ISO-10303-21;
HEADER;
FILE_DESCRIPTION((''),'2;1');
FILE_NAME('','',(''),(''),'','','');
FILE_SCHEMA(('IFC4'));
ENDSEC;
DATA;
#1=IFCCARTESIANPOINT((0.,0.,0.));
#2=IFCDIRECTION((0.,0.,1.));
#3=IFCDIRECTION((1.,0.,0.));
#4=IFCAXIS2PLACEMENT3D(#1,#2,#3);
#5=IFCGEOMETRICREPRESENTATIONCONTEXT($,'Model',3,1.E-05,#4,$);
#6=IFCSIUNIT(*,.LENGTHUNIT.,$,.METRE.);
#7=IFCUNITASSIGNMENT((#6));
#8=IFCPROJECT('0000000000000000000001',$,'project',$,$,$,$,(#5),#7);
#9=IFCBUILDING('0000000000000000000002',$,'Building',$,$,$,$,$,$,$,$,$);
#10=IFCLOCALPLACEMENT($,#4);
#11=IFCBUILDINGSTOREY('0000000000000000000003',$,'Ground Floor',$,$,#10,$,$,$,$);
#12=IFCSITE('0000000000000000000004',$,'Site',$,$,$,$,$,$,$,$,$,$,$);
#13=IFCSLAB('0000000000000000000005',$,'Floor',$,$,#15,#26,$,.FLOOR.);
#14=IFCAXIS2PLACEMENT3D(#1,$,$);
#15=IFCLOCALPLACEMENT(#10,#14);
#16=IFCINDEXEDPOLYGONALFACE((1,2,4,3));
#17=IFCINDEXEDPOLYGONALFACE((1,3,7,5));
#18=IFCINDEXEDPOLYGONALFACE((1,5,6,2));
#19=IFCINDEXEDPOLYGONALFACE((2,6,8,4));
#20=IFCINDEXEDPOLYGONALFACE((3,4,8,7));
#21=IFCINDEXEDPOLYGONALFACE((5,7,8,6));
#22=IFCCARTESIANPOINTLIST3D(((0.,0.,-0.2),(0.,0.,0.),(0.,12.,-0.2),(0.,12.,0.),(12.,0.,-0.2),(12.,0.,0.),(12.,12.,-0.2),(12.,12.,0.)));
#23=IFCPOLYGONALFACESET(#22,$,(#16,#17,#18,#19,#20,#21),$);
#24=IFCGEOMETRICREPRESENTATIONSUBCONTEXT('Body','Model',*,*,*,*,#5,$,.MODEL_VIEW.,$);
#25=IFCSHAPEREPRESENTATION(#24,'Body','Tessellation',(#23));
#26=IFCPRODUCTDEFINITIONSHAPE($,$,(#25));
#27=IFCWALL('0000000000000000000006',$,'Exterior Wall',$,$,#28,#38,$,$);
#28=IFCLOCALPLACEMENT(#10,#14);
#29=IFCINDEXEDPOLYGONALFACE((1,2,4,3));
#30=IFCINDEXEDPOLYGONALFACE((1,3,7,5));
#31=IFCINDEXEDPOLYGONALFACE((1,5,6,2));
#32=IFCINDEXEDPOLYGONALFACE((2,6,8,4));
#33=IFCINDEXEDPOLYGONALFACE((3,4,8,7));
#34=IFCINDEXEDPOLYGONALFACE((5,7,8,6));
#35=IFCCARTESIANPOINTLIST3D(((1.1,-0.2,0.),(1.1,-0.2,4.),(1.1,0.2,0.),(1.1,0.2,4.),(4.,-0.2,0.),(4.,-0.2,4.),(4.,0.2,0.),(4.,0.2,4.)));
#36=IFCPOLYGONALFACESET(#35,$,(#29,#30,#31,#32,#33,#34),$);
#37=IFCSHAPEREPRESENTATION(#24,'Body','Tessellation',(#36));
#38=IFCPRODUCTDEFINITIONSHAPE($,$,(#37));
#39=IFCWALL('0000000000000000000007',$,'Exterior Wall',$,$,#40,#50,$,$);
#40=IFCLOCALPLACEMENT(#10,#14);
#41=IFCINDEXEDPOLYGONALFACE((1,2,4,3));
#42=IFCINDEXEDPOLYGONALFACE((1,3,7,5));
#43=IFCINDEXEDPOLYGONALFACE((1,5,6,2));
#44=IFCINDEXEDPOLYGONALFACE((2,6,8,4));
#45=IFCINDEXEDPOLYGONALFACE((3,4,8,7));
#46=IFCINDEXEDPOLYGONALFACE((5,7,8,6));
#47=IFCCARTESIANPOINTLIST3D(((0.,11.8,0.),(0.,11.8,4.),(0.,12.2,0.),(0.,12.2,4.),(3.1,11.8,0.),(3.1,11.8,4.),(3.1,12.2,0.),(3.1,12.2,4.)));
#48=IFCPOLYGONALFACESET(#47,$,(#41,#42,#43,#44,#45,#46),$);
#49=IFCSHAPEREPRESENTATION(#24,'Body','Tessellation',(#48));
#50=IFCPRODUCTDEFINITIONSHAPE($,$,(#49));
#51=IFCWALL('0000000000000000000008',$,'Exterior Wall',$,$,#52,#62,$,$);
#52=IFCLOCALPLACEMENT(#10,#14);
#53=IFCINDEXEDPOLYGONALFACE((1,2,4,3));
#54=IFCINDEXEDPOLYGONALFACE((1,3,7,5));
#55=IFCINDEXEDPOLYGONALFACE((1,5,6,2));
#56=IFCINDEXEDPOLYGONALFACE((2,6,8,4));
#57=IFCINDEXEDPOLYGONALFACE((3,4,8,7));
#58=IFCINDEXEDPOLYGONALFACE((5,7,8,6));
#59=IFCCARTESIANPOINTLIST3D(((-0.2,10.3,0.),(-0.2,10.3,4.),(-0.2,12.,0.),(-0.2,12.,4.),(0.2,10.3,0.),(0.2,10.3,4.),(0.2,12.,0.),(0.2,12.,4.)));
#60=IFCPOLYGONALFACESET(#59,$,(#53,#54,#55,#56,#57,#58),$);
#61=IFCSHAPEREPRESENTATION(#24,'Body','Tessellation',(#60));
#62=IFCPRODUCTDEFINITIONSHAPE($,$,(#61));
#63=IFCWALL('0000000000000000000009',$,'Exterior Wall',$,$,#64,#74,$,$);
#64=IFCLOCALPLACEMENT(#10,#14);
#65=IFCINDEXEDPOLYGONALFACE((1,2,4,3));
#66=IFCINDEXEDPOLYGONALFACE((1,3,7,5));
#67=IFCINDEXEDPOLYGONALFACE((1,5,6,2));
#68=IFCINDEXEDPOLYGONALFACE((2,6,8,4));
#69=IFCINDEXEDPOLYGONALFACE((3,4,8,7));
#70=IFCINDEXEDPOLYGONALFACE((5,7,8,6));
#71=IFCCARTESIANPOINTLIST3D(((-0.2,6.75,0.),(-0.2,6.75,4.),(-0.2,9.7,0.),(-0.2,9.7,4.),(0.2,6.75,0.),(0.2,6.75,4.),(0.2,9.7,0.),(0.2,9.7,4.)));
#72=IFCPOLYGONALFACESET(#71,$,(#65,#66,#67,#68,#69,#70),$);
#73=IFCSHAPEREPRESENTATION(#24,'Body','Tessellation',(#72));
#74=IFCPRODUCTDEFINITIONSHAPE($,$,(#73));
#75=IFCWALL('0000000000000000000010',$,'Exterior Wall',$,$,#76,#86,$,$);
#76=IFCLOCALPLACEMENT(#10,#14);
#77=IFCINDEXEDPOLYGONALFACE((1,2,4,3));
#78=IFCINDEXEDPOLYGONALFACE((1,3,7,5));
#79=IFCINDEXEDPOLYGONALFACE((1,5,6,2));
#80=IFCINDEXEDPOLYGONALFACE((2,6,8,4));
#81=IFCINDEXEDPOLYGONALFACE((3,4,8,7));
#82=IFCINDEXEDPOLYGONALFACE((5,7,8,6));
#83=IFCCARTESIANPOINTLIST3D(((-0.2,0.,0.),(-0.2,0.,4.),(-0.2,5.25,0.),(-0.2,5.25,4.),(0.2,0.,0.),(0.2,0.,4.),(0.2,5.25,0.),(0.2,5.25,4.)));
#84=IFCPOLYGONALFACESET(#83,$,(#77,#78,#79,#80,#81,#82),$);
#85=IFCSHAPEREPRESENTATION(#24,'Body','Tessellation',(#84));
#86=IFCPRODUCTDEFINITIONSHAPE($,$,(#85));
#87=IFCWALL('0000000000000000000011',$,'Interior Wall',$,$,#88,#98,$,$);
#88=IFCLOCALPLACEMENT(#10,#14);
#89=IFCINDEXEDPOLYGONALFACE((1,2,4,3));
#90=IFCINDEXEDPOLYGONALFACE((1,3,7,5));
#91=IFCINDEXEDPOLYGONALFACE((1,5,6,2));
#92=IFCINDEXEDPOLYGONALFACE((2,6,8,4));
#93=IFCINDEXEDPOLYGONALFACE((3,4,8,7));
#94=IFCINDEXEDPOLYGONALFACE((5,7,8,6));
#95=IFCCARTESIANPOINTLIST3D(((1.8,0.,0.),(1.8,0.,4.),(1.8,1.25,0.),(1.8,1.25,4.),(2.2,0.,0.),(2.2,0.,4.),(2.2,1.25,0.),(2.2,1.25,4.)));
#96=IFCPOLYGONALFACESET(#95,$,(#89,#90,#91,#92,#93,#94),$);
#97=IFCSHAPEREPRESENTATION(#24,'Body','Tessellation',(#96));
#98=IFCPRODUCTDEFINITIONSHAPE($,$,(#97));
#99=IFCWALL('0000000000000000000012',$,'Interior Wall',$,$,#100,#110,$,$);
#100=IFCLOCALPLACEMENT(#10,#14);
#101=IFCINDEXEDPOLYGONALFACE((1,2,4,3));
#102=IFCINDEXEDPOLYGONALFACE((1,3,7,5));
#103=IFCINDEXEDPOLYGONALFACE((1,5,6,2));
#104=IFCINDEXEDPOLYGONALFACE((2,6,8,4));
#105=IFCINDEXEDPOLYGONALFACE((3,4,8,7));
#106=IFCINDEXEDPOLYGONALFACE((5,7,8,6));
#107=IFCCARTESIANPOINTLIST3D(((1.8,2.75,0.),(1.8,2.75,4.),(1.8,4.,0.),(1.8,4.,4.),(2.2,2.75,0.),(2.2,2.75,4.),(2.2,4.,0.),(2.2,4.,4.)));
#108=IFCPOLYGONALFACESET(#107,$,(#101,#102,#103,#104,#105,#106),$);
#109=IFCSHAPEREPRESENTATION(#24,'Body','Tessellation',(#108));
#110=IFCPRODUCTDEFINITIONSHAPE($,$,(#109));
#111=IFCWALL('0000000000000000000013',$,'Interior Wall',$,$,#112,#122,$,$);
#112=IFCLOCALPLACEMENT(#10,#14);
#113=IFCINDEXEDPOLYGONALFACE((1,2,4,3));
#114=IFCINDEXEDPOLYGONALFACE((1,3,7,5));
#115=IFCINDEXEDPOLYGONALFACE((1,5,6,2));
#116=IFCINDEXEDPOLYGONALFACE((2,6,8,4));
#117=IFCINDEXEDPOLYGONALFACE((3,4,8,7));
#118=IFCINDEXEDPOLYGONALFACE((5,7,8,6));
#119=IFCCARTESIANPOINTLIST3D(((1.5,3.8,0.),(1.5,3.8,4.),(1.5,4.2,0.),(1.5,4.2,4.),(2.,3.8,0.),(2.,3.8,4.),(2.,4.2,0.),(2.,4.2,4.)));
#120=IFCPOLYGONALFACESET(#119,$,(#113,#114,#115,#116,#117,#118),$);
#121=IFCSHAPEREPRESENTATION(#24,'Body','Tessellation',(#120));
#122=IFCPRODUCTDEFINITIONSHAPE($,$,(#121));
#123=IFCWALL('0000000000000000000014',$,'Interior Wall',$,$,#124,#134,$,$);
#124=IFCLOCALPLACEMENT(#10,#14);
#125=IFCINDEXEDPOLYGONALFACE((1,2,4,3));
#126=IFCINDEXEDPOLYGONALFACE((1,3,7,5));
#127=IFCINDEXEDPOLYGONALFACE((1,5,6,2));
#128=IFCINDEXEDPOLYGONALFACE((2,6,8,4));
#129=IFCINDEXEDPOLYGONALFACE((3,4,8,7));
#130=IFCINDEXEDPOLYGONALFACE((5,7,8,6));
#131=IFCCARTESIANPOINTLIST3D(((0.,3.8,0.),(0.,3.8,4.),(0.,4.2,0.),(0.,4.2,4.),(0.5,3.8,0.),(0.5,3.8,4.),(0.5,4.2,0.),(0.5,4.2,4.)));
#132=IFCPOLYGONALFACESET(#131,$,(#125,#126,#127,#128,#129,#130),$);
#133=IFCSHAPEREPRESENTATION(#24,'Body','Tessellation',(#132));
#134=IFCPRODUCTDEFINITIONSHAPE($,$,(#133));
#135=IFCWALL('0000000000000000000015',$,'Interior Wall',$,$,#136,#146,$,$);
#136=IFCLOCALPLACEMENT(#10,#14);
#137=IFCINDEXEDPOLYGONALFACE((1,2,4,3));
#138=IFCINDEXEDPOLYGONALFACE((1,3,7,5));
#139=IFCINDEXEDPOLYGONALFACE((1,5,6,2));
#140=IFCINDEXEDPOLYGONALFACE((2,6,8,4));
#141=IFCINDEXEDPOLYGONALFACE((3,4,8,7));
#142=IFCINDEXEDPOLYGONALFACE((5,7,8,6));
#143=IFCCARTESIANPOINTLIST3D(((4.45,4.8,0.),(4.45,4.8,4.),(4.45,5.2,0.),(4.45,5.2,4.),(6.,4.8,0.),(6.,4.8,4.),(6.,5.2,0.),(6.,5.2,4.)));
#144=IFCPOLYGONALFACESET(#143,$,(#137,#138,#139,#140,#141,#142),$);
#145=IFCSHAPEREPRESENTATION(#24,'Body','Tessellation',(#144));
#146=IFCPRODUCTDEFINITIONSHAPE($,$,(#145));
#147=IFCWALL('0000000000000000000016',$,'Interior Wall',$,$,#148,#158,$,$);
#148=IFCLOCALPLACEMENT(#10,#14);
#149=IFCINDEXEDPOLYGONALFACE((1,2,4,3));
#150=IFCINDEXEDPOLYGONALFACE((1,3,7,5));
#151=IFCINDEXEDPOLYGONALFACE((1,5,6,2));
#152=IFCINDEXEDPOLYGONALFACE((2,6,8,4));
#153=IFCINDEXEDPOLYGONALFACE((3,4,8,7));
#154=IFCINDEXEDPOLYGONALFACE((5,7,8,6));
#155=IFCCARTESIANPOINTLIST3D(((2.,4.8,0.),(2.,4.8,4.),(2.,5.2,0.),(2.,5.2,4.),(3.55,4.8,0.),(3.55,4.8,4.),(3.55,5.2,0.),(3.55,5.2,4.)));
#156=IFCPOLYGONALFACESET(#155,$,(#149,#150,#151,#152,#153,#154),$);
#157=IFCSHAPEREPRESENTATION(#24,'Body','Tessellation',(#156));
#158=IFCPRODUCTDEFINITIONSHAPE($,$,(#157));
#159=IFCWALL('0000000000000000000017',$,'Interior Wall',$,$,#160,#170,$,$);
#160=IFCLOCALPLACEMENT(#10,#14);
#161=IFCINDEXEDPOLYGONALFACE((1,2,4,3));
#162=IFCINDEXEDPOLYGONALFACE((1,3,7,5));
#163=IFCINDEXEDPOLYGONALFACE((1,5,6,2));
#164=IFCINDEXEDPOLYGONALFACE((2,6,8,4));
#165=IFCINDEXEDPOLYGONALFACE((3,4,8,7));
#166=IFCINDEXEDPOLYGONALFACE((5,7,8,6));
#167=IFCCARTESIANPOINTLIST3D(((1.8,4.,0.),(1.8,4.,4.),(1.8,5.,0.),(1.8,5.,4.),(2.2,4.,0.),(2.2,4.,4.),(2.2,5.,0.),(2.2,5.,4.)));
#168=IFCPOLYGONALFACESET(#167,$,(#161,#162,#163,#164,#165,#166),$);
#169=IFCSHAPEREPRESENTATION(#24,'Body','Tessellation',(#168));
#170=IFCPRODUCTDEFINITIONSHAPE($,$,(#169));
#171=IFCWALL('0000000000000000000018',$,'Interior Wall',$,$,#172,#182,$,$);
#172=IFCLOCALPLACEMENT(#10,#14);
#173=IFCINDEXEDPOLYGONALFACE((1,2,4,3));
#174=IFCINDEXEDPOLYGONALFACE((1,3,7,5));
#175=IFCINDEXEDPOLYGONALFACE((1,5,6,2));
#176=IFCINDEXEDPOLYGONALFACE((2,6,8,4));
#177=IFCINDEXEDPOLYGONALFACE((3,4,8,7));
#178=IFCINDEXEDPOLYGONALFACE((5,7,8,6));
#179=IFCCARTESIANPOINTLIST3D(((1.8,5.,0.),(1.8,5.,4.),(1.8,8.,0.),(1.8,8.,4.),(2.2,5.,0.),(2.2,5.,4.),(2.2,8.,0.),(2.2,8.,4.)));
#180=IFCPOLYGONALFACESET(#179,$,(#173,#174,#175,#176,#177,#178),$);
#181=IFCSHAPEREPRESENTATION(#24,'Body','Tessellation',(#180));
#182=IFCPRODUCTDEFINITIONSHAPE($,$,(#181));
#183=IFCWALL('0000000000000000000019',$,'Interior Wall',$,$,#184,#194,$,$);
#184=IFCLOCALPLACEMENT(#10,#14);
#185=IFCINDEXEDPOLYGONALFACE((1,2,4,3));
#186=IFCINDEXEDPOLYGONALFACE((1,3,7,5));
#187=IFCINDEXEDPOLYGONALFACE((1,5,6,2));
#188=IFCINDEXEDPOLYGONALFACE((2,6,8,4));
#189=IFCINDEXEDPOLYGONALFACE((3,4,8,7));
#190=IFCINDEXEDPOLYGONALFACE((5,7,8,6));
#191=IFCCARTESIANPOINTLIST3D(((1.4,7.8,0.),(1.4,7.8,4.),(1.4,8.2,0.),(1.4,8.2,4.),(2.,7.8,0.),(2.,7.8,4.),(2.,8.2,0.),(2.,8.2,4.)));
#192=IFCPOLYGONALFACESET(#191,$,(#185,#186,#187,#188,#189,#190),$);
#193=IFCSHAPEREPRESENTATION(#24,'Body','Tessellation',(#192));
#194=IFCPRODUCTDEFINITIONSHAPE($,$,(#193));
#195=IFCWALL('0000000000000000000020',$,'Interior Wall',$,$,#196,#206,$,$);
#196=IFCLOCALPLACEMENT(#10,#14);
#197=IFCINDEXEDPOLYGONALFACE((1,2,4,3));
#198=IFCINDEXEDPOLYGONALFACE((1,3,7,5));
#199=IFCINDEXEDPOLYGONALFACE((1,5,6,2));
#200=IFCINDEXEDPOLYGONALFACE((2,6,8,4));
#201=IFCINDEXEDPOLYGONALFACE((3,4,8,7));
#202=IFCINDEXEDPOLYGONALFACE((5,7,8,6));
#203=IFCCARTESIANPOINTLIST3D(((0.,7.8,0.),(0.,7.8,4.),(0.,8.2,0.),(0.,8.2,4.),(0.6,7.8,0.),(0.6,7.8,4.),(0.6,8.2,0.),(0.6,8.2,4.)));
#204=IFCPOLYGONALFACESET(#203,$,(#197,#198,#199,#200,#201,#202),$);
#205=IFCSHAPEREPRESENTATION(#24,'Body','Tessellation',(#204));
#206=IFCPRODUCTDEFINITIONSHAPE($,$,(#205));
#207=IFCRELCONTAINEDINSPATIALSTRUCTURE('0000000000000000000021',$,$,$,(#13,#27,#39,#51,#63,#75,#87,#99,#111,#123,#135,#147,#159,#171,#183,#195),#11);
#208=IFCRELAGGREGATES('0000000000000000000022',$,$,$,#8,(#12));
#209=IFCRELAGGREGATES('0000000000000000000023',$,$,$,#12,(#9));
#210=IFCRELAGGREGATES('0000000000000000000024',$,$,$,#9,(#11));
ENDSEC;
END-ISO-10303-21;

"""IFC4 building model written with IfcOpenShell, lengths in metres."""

from ifc_helpers import new_model, si_unit, frame, origin_with_axes, place, context, subcontext, project, spatial, indexed_curve, outline, extrude, element, save


model = new_model("IFC4")

# Units and contexts
model_context = context("Model", 3, precision=1e-05, world=origin_with_axes())
body_context = subcontext(model_context, "Body", "Model", "MODEL_VIEW")
ifc_project = project(units=[si_unit("LENGTHUNIT", "METRE")], contexts=[model_context])

# Site, building, storey
site = spatial("IfcSite", under=ifc_project, Name="Site")
building = spatial("IfcBuilding", under=site, Name="Building")
storey_placement = place(None, origin_with_axes())
storey = spatial("IfcBuildingStorey", under=building, at=storey_placement, Name="Ground Floor")

# Slab
slab_placement = place(storey_placement, frame((0.0, 0.0, -0.2), z_axis=(0.0, 0.0, 1.0), x_axis=(1.0, 0.0, 0.0)))
element("IfcSlab", 1, at=slab_placement, inside=storey, Name="Floor", PredefinedType="FLOOR", context=body_context, shape_type="SweptSolid", body=[
    extrude(outline(indexed_curve([(0.0, 0.0), (12.0, 0.0), (12.0, 12.0), (0.0, 12.0)])), None, (0.0, 0.0, 1.0), 0.2),
])

# Walls
wall_1_placement = place(storey_placement, frame((1.1, 0.0, 0.0), z_axis=(0.0, 0.0, 1.0), x_axis=(1.0, 0.0, 0.0)))
element("IfcWall", 2, at=wall_1_placement, inside=storey, Name="Exterior Wall", context=body_context, shape_type="SweptSolid", body=[
    extrude(outline(indexed_curve([(0.0, 0.0), (0.0, 0.4), (2.9, 0.4), (2.9, 0.0), (0.0, 0.0)], self_intersect=False)), frame((0.0, -0.2, 0.0), z_axis=(0.0, 0.0, 1.0), x_axis=(1.0, 0.0, 0.0)), (0.0, 0.0, 1.0), 4.0),
])
wall_2_placement = place(storey_placement, frame((3.1, 12.0, 0.0), z_axis=(0.0, 0.0, 1.0), x_axis=(-1.0, 0.0, 0.0)))
element("IfcWall", 3, at=wall_2_placement, inside=storey, Name="Exterior Wall", context=body_context, shape_type="SweptSolid", body=[
    extrude(outline(indexed_curve([(0.0, 0.0), (0.0, 0.4), (3.1, 0.4), (3.1, 0.0), (0.0, 0.0)], self_intersect=False)), frame((0.0, -0.2, 0.0), z_axis=(0.0, 0.0, 1.0), x_axis=(1.0, 0.0, 0.0)), (0.0, 0.0, 1.0), 4.0),
])
wall_3_placement = place(storey_placement, frame((0.0, 12.0, 0.0), z_axis=(0.0, 0.0, 1.0), x_axis=(0.0, -1.0, 0.0)))
element("IfcWall", 4, at=wall_3_placement, inside=storey, Name="Exterior Wall", context=body_context, shape_type="SweptSolid", body=[
    extrude(outline(indexed_curve([(0.0, 0.0), (0.0, 0.4), (1.7, 0.4), (1.7, 0.0), (0.0, 0.0)], self_intersect=False)), frame((0.0, -0.2, 0.0), z_axis=(0.0, 0.0, 1.0), x_axis=(1.0, 0.0, 0.0)), (0.0, 0.0, 1.0), 4.0),
])
wall_4_placement = place(storey_placement, frame((0.0, 9.7, 0.0), z_axis=(0.0, 0.0, 1.0), x_axis=(0.0, -1.0, 0.0)))
element("IfcWall", 5, at=wall_4_placement, inside=storey, Name="Exterior Wall", context=body_context, shape_type="SweptSolid", body=[
    extrude(outline(indexed_curve([(0.0, 0.0), (0.0, 0.4), (2.95, 0.4), (2.95, 0.0), (0.0, 0.0)], self_intersect=False)), frame((0.0, -0.2, 0.0), z_axis=(0.0, 0.0, 1.0), x_axis=(1.0, 0.0, 0.0)), (0.0, 0.0, 1.0), 4.0),
])
wall_5_placement = place(storey_placement, frame((0.0, 5.25, 0.0), z_axis=(0.0, 0.0, 1.0), x_axis=(0.0, -1.0, 0.0)))
element("IfcWall", 6, at=wall_5_placement, inside=storey, Name="Exterior Wall", context=body_context, shape_type="SweptSolid", body=[
    extrude(outline(indexed_curve([(0.0, 0.0), (0.0, 0.4), (5.25, 0.4), (5.25, 0.0), (0.0, 0.0)], self_intersect=False)), frame((0.0, -0.2, 0.0), z_axis=(0.0, 0.0, 1.0), x_axis=(1.0, 0.0, 0.0)), (0.0, 0.0, 1.0), 4.0),
])
for number, where, z_axis, x_axis, name in (
    (7, (2.0, 0.0, 0.0), (0.0, 0.0, 1.0), (0.0, 1.0, 0.0), "Interior Wall"),
    (8, (2.0, 2.75, 0.0), (0.0, 0.0, 1.0), (0.0, 1.0, 0.0), "Interior Wall"),
):
    element("IfcWall", number, at=place(storey_placement, frame(where, z_axis=z_axis, x_axis=x_axis)), inside=storey, Name=name, context=body_context, shape_type="SweptSolid", body=[
        extrude(outline(indexed_curve([(0.0, 0.0), (0.0, 0.4), (1.25, 0.4), (1.25, 0.0), (0.0, 0.0)], self_intersect=False)), frame((0.0, -0.2, 0.0), z_axis=(0.0, 0.0, 1.0), x_axis=(1.0, 0.0, 0.0)), (0.0, 0.0, 1.0), 4.0),
    ])
for number, where, z_axis, x_axis, name in (
    (9, (2.0, 4.0, 0.0), (0.0, 0.0, 1.0), (-1.0, 0.0, 0.0), "Interior Wall"),
    (10, (0.5, 4.0, 0.0), (0.0, 0.0, 1.0), (-1.0, 0.0, 0.0), "Interior Wall"),
):
    element("IfcWall", number, at=place(storey_placement, frame(where, z_axis=z_axis, x_axis=x_axis)), inside=storey, Name=name, context=body_context, shape_type="SweptSolid", body=[
        extrude(outline(indexed_curve([(0.0, 0.0), (0.0, 0.4), (0.5, 0.4), (0.5, 0.0), (0.0, 0.0)], self_intersect=False)), frame((0.0, -0.2, 0.0), z_axis=(0.0, 0.0, 1.0), x_axis=(1.0, 0.0, 0.0)), (0.0, 0.0, 1.0), 4.0),
    ])
for number, where, z_axis, x_axis, name in (
    (11, (6.0, 5.0, 0.0), (0.0, 0.0, 1.0), (-1.0, 0.0, 0.0), "Interior Wall"),
    (12, (3.55, 5.0, 0.0), (0.0, 0.0, 1.0), (-1.0, 0.0, 0.0), "Interior Wall"),
):
    element("IfcWall", number, at=place(storey_placement, frame(where, z_axis=z_axis, x_axis=x_axis)), inside=storey, Name=name, context=body_context, shape_type="SweptSolid", body=[
        extrude(outline(indexed_curve([(0.0, 0.0), (0.0, 0.4), (1.55, 0.4), (1.55, 0.0), (0.0, 0.0)], self_intersect=False)), frame((0.0, -0.2, 0.0), z_axis=(0.0, 0.0, 1.0), x_axis=(1.0, 0.0, 0.0)), (0.0, 0.0, 1.0), 4.0),
    ])
wall_6_placement = place(storey_placement, frame((2.0, 5.0, 0.0), z_axis=(0.0, 0.0, 1.0), x_axis=(0.0, -1.0, 0.0)))
element("IfcWall", 13, at=wall_6_placement, inside=storey, Name="Interior Wall", context=body_context, shape_type="SweptSolid", body=[
    extrude(outline(indexed_curve([(0.0, 0.0), (0.0, 0.4), (1.0, 0.4), (1.0, 0.0), (0.0, 0.0)], self_intersect=False)), frame((0.0, -0.2, 0.0), z_axis=(0.0, 0.0, 1.0), x_axis=(1.0, 0.0, 0.0)), (0.0, 0.0, 1.0), 4.0),
])
wall_7_placement = place(storey_placement, frame((2.0, 5.0, 0.0), z_axis=(0.0, 0.0, 1.0), x_axis=(0.0, 1.0, 0.0)))
element("IfcWall", 14, at=wall_7_placement, inside=storey, Name="Interior Wall", context=body_context, shape_type="SweptSolid", body=[
    extrude(outline(indexed_curve([(0.0, 0.0), (0.0, 0.4), (3.0, 0.4), (3.0, 0.0), (0.0, 0.0)], self_intersect=False)), frame((0.0, -0.2, 0.0), z_axis=(0.0, 0.0, 1.0), x_axis=(1.0, 0.0, 0.0)), (0.0, 0.0, 1.0), 4.0),
])
for number, where, z_axis, x_axis, name in (
    (15, (2.0, 8.0, 0.0), (0.0, 0.0, 1.0), (-1.0, 0.0, 0.0), "Interior Wall"),
    (16, (0.6, 8.0, 0.0), (0.0, 0.0, 1.0), (-1.0, 0.0, 0.0), "Interior Wall"),
):
    element("IfcWall", number, at=place(storey_placement, frame(where, z_axis=z_axis, x_axis=x_axis)), inside=storey, Name=name, context=body_context, shape_type="SweptSolid", body=[
        extrude(outline(indexed_curve([(0.0, 0.0), (0.0, 0.4), (0.6, 0.4), (0.6, 0.0), (0.0, 0.0)], self_intersect=False)), frame((0.0, -0.2, 0.0), z_axis=(0.0, 0.0, 1.0), x_axis=(1.0, 0.0, 0.0)), (0.0, 0.0, 1.0), 4.0),
    ])

save(model, "model.ifc")
